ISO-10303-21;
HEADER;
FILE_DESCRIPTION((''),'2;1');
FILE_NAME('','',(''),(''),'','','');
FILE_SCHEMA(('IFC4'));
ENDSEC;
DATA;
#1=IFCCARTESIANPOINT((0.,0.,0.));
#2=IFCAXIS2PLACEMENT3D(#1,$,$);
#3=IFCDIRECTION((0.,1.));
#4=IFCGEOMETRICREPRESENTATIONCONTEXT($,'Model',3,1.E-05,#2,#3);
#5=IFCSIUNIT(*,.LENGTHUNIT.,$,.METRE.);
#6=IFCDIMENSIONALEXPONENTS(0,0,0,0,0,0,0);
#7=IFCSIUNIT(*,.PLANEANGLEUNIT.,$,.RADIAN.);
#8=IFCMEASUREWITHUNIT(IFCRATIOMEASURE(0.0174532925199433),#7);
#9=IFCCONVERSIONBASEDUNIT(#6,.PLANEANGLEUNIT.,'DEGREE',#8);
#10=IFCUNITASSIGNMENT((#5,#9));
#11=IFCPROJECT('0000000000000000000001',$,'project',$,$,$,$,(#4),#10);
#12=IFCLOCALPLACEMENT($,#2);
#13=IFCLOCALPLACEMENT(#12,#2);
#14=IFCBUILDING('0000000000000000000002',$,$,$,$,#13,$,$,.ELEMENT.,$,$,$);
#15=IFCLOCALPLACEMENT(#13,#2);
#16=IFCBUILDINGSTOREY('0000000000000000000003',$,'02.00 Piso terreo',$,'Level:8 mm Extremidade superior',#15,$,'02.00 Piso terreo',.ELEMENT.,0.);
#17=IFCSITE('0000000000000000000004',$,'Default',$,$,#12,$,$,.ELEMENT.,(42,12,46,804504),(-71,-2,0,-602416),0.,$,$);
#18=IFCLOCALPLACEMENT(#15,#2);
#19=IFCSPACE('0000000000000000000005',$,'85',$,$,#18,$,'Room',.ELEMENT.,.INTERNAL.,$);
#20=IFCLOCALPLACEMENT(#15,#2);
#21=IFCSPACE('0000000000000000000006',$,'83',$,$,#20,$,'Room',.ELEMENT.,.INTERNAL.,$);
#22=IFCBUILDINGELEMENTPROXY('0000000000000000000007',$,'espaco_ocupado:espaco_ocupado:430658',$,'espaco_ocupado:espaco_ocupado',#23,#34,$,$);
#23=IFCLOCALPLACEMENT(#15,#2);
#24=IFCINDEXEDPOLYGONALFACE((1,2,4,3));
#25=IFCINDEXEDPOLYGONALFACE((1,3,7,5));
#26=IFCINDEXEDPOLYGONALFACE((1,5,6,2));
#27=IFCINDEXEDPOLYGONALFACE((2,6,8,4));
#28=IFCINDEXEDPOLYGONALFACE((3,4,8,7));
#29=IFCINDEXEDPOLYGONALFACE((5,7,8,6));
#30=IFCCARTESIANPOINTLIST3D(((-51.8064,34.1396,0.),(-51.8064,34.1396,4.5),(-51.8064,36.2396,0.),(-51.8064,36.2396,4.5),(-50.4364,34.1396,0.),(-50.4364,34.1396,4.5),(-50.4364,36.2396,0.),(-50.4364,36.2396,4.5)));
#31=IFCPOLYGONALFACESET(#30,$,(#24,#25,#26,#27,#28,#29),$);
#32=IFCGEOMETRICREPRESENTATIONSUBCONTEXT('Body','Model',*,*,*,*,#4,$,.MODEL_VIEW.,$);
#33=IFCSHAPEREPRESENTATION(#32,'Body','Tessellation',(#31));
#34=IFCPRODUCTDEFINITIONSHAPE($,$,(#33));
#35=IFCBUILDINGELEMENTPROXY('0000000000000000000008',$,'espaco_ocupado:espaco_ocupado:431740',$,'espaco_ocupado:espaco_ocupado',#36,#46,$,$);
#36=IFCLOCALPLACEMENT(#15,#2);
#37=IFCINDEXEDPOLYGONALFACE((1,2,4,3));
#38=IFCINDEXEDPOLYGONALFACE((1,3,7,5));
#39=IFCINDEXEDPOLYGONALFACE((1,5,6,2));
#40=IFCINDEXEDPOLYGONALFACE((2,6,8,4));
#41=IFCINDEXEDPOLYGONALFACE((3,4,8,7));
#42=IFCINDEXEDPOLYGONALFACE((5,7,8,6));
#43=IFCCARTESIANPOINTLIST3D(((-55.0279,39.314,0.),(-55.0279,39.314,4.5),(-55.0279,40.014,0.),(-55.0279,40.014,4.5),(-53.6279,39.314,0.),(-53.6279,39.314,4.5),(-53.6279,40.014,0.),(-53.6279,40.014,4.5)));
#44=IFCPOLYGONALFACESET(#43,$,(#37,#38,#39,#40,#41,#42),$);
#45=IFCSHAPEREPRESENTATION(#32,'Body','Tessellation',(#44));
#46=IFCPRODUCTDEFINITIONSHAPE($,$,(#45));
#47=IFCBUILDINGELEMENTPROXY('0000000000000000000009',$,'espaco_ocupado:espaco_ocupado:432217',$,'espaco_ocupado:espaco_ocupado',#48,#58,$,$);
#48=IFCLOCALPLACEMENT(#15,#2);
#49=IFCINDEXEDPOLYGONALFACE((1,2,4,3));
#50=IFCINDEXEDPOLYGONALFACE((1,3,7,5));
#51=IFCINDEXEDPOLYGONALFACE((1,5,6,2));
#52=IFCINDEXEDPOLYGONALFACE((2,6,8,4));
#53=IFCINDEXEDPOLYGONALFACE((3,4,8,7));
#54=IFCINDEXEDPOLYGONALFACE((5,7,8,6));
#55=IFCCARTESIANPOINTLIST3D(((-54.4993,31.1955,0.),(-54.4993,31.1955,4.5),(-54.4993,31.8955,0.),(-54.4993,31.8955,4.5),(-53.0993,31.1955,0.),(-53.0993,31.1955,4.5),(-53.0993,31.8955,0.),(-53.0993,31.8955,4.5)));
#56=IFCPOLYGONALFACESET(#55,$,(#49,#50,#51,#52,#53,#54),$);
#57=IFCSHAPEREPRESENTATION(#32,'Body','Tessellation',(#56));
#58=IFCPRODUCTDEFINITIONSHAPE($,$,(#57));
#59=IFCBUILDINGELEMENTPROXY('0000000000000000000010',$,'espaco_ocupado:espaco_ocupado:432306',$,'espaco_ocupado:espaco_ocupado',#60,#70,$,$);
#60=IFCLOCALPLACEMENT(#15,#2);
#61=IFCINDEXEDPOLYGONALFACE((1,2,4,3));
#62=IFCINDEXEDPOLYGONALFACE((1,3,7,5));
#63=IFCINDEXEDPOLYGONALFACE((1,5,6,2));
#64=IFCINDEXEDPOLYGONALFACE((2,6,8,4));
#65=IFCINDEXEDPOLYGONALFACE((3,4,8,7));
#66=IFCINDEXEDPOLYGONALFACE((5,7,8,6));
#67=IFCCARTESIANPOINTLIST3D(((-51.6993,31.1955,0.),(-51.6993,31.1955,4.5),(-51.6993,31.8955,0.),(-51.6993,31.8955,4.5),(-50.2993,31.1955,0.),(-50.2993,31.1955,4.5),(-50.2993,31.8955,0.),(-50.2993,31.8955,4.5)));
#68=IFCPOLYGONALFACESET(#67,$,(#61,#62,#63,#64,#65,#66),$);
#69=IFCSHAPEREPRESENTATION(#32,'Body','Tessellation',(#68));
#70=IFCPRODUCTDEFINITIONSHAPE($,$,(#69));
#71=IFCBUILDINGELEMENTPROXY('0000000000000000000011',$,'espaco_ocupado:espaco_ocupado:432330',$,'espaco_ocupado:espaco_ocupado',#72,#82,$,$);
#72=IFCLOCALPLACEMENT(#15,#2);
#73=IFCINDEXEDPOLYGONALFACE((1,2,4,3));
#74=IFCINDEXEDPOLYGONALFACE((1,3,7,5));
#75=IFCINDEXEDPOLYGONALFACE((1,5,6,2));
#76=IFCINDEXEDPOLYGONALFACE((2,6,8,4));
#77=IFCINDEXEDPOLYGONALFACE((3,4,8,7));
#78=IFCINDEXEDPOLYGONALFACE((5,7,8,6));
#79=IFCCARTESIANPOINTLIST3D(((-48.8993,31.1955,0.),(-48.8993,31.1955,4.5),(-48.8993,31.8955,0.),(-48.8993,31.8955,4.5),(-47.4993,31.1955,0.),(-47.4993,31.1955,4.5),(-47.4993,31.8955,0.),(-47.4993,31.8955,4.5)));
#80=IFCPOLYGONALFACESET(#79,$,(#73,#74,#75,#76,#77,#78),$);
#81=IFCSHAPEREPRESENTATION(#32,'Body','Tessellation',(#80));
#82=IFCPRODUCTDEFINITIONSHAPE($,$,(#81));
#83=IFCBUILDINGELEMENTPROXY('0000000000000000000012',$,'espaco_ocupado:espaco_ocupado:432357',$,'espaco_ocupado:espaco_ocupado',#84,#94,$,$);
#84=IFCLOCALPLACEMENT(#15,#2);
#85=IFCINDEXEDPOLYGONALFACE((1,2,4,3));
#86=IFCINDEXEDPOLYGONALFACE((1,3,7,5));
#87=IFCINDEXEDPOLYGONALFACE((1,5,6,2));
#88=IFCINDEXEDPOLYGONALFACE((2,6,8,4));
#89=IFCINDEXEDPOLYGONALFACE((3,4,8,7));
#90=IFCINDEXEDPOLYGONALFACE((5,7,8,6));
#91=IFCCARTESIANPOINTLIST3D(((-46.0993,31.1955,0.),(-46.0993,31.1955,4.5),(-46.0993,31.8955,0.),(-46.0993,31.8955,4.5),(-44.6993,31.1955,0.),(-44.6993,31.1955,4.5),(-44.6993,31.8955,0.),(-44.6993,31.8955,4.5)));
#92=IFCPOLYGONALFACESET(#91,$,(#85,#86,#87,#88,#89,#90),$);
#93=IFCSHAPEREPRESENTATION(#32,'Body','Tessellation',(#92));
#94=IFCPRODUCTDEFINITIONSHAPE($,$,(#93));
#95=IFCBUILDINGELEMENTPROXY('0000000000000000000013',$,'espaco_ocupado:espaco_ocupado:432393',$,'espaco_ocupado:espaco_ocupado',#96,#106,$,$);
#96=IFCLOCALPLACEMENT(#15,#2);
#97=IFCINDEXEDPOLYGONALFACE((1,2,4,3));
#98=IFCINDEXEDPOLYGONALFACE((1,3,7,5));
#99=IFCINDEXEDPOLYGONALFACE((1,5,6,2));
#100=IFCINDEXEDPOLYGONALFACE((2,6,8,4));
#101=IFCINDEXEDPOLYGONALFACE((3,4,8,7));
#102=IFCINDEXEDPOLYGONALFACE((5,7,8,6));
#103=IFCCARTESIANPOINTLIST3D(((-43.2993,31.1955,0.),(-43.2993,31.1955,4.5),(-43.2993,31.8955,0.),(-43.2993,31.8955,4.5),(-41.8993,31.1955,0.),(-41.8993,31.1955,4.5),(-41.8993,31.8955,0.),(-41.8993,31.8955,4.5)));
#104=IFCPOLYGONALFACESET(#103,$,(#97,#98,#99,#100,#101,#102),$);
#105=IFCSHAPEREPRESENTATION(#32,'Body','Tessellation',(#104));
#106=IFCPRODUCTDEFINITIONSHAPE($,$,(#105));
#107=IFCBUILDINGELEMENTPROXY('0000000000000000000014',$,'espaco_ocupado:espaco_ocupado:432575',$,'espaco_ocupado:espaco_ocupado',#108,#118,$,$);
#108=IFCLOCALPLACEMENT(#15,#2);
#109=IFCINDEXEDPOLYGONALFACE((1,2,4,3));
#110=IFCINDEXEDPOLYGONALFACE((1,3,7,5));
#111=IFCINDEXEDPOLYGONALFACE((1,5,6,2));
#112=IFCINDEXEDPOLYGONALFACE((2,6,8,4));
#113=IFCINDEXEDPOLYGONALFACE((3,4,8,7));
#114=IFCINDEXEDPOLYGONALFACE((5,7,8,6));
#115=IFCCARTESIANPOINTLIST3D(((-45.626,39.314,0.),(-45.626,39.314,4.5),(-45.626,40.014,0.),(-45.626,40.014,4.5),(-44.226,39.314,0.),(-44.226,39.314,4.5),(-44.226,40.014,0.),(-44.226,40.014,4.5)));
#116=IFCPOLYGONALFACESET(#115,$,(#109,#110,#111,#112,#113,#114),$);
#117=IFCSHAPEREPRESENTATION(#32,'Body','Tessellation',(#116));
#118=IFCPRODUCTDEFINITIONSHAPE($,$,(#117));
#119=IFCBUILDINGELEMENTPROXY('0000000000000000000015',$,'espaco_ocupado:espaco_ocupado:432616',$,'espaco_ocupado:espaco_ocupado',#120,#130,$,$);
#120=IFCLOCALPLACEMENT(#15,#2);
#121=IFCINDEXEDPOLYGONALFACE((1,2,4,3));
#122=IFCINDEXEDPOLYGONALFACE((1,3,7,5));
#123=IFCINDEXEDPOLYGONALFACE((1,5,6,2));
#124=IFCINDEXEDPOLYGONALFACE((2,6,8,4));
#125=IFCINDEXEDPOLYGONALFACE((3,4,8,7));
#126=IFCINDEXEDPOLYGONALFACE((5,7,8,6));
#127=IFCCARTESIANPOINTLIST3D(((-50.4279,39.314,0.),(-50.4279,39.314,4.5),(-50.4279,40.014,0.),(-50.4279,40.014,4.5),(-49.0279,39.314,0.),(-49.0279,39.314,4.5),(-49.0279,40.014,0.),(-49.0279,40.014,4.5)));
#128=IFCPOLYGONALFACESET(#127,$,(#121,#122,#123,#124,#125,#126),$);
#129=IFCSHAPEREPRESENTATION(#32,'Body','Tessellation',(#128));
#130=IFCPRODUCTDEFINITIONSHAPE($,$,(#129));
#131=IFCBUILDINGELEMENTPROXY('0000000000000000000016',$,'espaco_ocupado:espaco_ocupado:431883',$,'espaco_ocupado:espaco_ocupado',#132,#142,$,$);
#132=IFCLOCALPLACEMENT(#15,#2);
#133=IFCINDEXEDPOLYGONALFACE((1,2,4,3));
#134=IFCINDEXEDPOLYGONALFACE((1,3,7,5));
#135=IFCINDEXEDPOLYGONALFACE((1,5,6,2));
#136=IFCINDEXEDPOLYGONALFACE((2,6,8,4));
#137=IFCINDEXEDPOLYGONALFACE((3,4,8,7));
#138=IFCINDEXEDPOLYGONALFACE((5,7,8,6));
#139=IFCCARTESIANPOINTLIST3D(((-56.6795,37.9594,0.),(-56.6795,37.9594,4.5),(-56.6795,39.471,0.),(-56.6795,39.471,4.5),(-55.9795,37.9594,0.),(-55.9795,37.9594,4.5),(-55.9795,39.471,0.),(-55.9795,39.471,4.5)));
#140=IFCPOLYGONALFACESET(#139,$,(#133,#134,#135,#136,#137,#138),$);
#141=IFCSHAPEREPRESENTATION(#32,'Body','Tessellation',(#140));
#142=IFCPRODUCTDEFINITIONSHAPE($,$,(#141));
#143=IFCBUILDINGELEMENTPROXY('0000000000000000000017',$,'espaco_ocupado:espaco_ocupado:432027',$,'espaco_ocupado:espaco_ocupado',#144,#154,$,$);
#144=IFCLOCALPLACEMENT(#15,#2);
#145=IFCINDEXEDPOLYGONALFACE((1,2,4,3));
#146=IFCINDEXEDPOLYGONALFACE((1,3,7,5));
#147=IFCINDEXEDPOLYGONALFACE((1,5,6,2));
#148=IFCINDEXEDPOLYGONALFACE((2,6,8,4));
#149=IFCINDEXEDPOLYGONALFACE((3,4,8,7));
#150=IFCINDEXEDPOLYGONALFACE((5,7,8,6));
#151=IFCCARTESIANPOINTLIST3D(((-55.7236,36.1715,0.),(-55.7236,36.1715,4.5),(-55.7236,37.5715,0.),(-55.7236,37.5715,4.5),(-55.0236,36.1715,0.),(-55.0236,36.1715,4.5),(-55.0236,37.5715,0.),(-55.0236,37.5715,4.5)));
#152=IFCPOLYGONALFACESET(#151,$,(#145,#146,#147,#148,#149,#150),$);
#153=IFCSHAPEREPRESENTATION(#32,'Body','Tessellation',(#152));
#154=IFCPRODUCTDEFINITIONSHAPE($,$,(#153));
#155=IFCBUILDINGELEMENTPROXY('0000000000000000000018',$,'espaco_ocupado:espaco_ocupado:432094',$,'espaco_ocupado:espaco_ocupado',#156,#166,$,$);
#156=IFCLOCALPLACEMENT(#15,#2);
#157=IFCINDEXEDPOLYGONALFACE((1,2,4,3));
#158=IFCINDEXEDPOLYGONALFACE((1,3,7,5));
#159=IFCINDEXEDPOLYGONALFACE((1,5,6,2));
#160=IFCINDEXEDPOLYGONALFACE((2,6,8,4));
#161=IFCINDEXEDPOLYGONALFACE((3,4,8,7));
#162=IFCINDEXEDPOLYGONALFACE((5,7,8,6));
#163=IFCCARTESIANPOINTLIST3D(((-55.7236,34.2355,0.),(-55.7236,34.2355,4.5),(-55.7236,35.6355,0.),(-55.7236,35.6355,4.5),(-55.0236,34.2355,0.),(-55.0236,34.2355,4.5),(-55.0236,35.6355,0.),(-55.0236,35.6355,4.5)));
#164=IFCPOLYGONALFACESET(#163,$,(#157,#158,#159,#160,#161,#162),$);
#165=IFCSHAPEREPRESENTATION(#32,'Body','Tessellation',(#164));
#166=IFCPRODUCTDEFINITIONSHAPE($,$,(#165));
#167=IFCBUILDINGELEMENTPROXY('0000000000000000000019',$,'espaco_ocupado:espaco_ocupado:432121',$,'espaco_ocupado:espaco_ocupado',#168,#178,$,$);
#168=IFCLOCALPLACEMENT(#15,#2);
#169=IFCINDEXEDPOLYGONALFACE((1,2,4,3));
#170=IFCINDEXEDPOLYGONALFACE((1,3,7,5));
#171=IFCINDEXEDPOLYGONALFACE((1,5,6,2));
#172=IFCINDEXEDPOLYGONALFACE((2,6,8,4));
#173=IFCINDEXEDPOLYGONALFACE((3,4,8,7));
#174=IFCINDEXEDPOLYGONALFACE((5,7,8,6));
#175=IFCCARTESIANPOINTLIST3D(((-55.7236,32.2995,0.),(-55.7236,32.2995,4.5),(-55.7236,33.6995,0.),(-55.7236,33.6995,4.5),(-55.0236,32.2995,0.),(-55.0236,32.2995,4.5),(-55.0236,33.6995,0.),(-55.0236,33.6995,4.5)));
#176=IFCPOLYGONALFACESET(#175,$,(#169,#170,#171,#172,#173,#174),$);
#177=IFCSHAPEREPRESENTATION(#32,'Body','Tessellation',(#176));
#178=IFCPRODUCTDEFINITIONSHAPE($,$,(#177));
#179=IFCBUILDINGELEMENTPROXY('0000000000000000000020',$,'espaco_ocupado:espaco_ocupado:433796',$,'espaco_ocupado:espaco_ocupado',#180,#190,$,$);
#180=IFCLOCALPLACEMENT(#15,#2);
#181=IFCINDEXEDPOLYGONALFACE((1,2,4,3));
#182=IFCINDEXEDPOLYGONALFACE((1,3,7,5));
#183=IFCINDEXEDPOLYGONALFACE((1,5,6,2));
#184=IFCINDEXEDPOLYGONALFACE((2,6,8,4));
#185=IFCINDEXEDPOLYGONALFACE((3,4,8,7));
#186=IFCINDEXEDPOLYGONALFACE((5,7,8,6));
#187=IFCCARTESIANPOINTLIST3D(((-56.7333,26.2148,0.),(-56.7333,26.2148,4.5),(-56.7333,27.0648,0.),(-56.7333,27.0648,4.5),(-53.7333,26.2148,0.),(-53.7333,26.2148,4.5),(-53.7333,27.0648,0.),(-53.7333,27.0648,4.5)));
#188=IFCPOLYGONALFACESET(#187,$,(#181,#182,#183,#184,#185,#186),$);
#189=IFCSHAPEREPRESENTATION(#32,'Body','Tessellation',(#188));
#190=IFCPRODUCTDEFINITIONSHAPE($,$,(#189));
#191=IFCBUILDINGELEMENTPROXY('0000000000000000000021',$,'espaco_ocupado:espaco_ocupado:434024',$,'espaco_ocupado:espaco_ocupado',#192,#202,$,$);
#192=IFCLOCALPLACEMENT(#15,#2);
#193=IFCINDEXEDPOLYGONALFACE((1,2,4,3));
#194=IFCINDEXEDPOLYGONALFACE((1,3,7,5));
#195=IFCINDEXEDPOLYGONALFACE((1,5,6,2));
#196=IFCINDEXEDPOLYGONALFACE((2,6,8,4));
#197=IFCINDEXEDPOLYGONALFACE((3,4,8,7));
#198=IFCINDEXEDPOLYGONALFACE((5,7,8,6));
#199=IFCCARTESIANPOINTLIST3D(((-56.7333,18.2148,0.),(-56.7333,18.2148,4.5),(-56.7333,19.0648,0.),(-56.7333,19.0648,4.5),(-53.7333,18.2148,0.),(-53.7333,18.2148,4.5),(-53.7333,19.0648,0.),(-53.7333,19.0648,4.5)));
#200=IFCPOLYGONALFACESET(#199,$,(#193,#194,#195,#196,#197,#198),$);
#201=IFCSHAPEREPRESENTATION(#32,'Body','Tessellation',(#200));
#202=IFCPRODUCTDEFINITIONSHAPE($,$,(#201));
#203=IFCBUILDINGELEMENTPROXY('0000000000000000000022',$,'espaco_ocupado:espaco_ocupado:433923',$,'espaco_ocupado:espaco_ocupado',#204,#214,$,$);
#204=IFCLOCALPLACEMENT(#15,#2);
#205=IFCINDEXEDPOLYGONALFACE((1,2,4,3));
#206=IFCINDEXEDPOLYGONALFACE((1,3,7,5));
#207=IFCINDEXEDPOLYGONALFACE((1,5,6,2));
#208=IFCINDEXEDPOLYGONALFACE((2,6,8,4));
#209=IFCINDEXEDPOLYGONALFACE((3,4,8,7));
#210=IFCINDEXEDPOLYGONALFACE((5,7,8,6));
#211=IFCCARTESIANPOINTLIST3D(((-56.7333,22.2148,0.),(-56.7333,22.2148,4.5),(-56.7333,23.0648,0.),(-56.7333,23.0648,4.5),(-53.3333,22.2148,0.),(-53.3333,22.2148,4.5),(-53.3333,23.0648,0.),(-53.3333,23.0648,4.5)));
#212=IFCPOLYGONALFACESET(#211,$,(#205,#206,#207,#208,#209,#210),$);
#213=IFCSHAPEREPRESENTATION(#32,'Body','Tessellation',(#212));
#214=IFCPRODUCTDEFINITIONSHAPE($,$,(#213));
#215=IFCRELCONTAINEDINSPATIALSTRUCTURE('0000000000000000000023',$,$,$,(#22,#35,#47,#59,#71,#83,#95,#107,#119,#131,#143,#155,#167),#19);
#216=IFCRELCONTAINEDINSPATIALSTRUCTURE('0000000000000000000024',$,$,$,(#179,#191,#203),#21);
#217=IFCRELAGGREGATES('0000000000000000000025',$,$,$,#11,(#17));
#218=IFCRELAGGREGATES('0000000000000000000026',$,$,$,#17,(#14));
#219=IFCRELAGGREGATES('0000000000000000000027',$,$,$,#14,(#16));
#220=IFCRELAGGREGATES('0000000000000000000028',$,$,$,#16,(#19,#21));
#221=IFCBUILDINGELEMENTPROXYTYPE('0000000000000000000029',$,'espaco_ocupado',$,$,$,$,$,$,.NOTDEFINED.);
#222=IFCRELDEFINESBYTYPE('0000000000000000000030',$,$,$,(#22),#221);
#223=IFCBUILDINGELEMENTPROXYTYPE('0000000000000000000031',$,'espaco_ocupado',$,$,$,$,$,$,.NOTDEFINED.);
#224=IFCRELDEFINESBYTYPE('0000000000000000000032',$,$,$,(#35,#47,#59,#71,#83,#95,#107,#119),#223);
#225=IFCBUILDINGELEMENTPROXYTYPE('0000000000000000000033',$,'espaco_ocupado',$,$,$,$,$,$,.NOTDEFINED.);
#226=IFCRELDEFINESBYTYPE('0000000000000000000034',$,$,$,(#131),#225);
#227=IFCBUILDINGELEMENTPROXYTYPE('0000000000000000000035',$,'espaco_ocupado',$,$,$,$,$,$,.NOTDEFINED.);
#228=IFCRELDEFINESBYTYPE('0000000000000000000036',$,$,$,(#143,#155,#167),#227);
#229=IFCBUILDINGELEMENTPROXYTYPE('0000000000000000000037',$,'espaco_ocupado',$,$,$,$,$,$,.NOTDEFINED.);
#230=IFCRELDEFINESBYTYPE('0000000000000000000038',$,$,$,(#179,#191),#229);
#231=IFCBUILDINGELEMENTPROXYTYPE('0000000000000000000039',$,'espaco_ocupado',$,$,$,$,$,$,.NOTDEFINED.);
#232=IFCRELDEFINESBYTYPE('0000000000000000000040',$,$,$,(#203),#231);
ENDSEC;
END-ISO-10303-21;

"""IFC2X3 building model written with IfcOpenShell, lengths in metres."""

from ifc_helpers import new_model, entity, si_unit, converted_unit, direction, frame, origin, origin_2d_with_axis, place, context, subcontext, project, spatial, rectangle, extrude, source, transform, mapped, type_object, type_shapes, element, save


model = new_model("IFC2X3")

# Units and contexts
model_context = context("Model", 3, precision=1e-05, world=origin(), true_north=direction((0.0, 1.0)))
body_context = subcontext(model_context, "Body", "Model", "MODEL_VIEW")
ifc_project = project(units=[si_unit("LENGTHUNIT", "METRE"), converted_unit("PLANEANGLEUNIT", "DEGREE", entity("IfcRatioMeasure", 0.0174532925199433), si_unit("PLANEANGLEUNIT", "RADIAN"), dimensions=[0, 0, 0, 0, 0, 0, 0])], contexts=[model_context])

# Site, building, storey, space
site_placement = place(None, origin())
site = spatial("IfcSite", under=ifc_project, at=site_placement, Name="Default", CompositionType="ELEMENT", RefLatitude=(42, 12, 46, 804504), RefLongitude=(-71, -2, 0, -602416), RefElevation=0.0)
building_placement = place(site_placement, origin())
building = spatial("IfcBuilding", under=site, at=building_placement, CompositionType="ELEMENT")
storey_placement = place(building_placement, origin())
storey = spatial("IfcBuildingStorey", under=building, at=storey_placement, Name="02.00 Piso terreo", ObjectType="Level:8 mm Extremidade superior", LongName="02.00 Piso terreo", CompositionType="ELEMENT", Elevation=0.0)
space_1_placement = place(storey_placement, origin())
space_1 = spatial("IfcSpace", under=storey, at=space_1_placement, Name="85", LongName="Room", CompositionType="ELEMENT", InteriorOrExteriorSpace="INTERNAL")

# Building element proxies
building_element_proxy_type_1 = type_object("IfcBuildingElementProxyType", Name="espaco_ocupado", PredefinedType="NOTDEFINED")
shared_shape_1 = source(origin(), body_context, "Body", "SweptSolid", [
    extrude(rectangle(XDim=1.37, YDim=2.1, at=origin_2d_with_axis()), frame((0.0, 0.0, 0.0), z_axis=(0.0, 0.0, 1.0), x_axis=(-1.0, 0.0, 0.0)), (0.0, 0.0, 1.0), 4.5),
])
type_shapes(building_element_proxy_type_1, [shared_shape_1])
proxy_1_placement = place(space_1_placement, frame((-51.1214, 35.1896, 0.0)))
element("IfcBuildingElementProxy", 1, at=proxy_1_placement, inside=space_1, type_object=building_element_proxy_type_1, Name="espaco_ocupado:espaco_ocupado:430658", ObjectType="espaco_ocupado:espaco_ocupado", context=body_context, shape_type="MappedRepresentation", body=[
    mapped(shared_shape_1, transform((0.0, 0.0, 0.0), scale=1.0)),
])
building_element_proxy_type_2 = type_object("IfcBuildingElementProxyType", Name="espaco_ocupado", PredefinedType="NOTDEFINED")
shared_shape_2 = source(origin(), body_context, "Body", "SweptSolid", [
    extrude(rectangle(XDim=1.4, YDim=0.7, at=origin_2d_with_axis()), frame((0.0, 0.0, 0.0), z_axis=(0.0, 0.0, 1.0), x_axis=(-1.0, 0.0, 0.0)), (0.0, 0.0, 1.0), 4.5),
])
type_shapes(building_element_proxy_type_2, [shared_shape_2])
for number, where, name in (
    (2, (-54.3279, 39.664, 0.0), "espaco_ocupado:espaco_ocupado:431740"),
    (3, (-53.7993, 31.5455, 0.0), "espaco_ocupado:espaco_ocupado:432217"),
    (4, (-50.9993, 31.5455, 0.0), "espaco_ocupado:espaco_ocupado:432306"),
    (5, (-48.1993, 31.5455, 0.0), "espaco_ocupado:espaco_ocupado:432330"),
    (6, (-45.3993, 31.5455, 0.0), "espaco_ocupado:espaco_ocupado:432357"),
    (7, (-42.5993, 31.5455, 0.0), "espaco_ocupado:espaco_ocupado:432393"),
    (8, (-44.926, 39.664, 0.0), "espaco_ocupado:espaco_ocupado:432575"),
    (9, (-49.7279, 39.664, 0.0), "espaco_ocupado:espaco_ocupado:432616"),
):
    element("IfcBuildingElementProxy", number, at=place(space_1_placement, frame(where)), inside=space_1, type_object=building_element_proxy_type_2, Name=name, ObjectType="espaco_ocupado:espaco_ocupado", context=body_context, shape_type="MappedRepresentation", body=[
        mapped(shared_shape_2, transform((0.0, 0.0, 0.0), scale=1.0)),
    ])
building_element_proxy_type_3 = type_object("IfcBuildingElementProxyType", Name="espaco_ocupado", PredefinedType="NOTDEFINED")
shared_shape_3 = source(origin(), body_context, "Body", "SweptSolid", [
    extrude(rectangle(XDim=0.7, YDim=1.5116, at=origin_2d_with_axis()), frame((0.0, 0.0, 0.0), z_axis=(0.0, 0.0, 1.0), x_axis=(-1.0, 0.0, 0.0)), (0.0, 0.0, 1.0), 4.5),
])
type_shapes(building_element_proxy_type_3, [shared_shape_3])
proxy_2_placement = place(space_1_placement, frame((-56.3295, 38.7152, 0.0)))
element("IfcBuildingElementProxy", 10, at=proxy_2_placement, inside=space_1, type_object=building_element_proxy_type_3, Name="espaco_ocupado:espaco_ocupado:431883", ObjectType="espaco_ocupado:espaco_ocupado", context=body_context, shape_type="MappedRepresentation", body=[
    mapped(shared_shape_3, transform((0.0, 0.0, 0.0), scale=1.0)),
])
building_element_proxy_type_4 = type_object("IfcBuildingElementProxyType", Name="espaco_ocupado", PredefinedType="NOTDEFINED")
shared_shape_4 = source(origin(), body_context, "Body", "SweptSolid", [
    extrude(rectangle(XDim=0.7, YDim=1.4, at=origin_2d_with_axis()), frame((0.0, 0.0, 0.0), z_axis=(0.0, 0.0, 1.0), x_axis=(-1.0, 0.0, 0.0)), (0.0, 0.0, 1.0), 4.5),
])
type_shapes(building_element_proxy_type_4, [shared_shape_4])
for number, where, name in (
    (11, (-55.3736, 36.8715, 0.0), "espaco_ocupado:espaco_ocupado:432027"),
    (12, (-55.3736, 34.9355, 0.0), "espaco_ocupado:espaco_ocupado:432094"),
    (13, (-55.3736, 32.9995, 0.0), "espaco_ocupado:espaco_ocupado:432121"),
):
    element("IfcBuildingElementProxy", number, at=place(space_1_placement, frame(where)), inside=space_1, type_object=building_element_proxy_type_4, Name=name, ObjectType="espaco_ocupado:espaco_ocupado", context=body_context, shape_type="MappedRepresentation", body=[
        mapped(shared_shape_4, transform((0.0, 0.0, 0.0), scale=1.0)),
    ])

# Shared definitions
space_2_placement = place(storey_placement, origin())
space_2 = spatial("IfcSpace", under=storey, at=space_2_placement, Name="83", LongName="Room", CompositionType="ELEMENT", InteriorOrExteriorSpace="INTERNAL")

# Building element proxies
building_element_proxy_type_5 = type_object("IfcBuildingElementProxyType", Name="espaco_ocupado", PredefinedType="NOTDEFINED")
shared_shape_5 = source(origin(), body_context, "Body", "SweptSolid", [
    extrude(rectangle(XDim=3.0, YDim=0.85, at=origin_2d_with_axis()), frame((0.0, 0.0, 0.0), z_axis=(0.0, 0.0, 1.0), x_axis=(-1.0, 0.0, 0.0)), (0.0, 0.0, 1.0), 4.5),
])
type_shapes(building_element_proxy_type_5, [shared_shape_5])
for number, where, name in (
    (14, (-55.2333, 26.6398, 0.0), "espaco_ocupado:espaco_ocupado:433796"),
    (15, (-55.2333, 18.6398, 0.0), "espaco_ocupado:espaco_ocupado:434024"),
):
    element("IfcBuildingElementProxy", number, at=place(space_2_placement, frame(where)), inside=space_2, type_object=building_element_proxy_type_5, Name=name, ObjectType="espaco_ocupado:espaco_ocupado", context=body_context, shape_type="MappedRepresentation", body=[
        mapped(shared_shape_5, transform((0.0, 0.0, 0.0), scale=1.0)),
    ])
building_element_proxy_type_6 = type_object("IfcBuildingElementProxyType", Name="espaco_ocupado", PredefinedType="NOTDEFINED")
shared_shape_6 = source(origin(), body_context, "Body", "SweptSolid", [
    extrude(rectangle(XDim=3.4, YDim=0.85, at=origin_2d_with_axis()), frame((0.0, 0.0, 0.0), z_axis=(0.0, 0.0, 1.0), x_axis=(-1.0, 0.0, 0.0)), (0.0, 0.0, 1.0), 4.5),
])
type_shapes(building_element_proxy_type_6, [shared_shape_6])
proxy_3_placement = place(space_2_placement, frame((-55.0333, 22.6398, 0.0)))
element("IfcBuildingElementProxy", 16, at=proxy_3_placement, inside=space_2, type_object=building_element_proxy_type_6, Name="espaco_ocupado:espaco_ocupado:433923", ObjectType="espaco_ocupado:espaco_ocupado", context=body_context, shape_type="MappedRepresentation", body=[
    mapped(shared_shape_6, transform((0.0, 0.0, 0.0), scale=1.0)),
])

save(model, "model.ifc")
